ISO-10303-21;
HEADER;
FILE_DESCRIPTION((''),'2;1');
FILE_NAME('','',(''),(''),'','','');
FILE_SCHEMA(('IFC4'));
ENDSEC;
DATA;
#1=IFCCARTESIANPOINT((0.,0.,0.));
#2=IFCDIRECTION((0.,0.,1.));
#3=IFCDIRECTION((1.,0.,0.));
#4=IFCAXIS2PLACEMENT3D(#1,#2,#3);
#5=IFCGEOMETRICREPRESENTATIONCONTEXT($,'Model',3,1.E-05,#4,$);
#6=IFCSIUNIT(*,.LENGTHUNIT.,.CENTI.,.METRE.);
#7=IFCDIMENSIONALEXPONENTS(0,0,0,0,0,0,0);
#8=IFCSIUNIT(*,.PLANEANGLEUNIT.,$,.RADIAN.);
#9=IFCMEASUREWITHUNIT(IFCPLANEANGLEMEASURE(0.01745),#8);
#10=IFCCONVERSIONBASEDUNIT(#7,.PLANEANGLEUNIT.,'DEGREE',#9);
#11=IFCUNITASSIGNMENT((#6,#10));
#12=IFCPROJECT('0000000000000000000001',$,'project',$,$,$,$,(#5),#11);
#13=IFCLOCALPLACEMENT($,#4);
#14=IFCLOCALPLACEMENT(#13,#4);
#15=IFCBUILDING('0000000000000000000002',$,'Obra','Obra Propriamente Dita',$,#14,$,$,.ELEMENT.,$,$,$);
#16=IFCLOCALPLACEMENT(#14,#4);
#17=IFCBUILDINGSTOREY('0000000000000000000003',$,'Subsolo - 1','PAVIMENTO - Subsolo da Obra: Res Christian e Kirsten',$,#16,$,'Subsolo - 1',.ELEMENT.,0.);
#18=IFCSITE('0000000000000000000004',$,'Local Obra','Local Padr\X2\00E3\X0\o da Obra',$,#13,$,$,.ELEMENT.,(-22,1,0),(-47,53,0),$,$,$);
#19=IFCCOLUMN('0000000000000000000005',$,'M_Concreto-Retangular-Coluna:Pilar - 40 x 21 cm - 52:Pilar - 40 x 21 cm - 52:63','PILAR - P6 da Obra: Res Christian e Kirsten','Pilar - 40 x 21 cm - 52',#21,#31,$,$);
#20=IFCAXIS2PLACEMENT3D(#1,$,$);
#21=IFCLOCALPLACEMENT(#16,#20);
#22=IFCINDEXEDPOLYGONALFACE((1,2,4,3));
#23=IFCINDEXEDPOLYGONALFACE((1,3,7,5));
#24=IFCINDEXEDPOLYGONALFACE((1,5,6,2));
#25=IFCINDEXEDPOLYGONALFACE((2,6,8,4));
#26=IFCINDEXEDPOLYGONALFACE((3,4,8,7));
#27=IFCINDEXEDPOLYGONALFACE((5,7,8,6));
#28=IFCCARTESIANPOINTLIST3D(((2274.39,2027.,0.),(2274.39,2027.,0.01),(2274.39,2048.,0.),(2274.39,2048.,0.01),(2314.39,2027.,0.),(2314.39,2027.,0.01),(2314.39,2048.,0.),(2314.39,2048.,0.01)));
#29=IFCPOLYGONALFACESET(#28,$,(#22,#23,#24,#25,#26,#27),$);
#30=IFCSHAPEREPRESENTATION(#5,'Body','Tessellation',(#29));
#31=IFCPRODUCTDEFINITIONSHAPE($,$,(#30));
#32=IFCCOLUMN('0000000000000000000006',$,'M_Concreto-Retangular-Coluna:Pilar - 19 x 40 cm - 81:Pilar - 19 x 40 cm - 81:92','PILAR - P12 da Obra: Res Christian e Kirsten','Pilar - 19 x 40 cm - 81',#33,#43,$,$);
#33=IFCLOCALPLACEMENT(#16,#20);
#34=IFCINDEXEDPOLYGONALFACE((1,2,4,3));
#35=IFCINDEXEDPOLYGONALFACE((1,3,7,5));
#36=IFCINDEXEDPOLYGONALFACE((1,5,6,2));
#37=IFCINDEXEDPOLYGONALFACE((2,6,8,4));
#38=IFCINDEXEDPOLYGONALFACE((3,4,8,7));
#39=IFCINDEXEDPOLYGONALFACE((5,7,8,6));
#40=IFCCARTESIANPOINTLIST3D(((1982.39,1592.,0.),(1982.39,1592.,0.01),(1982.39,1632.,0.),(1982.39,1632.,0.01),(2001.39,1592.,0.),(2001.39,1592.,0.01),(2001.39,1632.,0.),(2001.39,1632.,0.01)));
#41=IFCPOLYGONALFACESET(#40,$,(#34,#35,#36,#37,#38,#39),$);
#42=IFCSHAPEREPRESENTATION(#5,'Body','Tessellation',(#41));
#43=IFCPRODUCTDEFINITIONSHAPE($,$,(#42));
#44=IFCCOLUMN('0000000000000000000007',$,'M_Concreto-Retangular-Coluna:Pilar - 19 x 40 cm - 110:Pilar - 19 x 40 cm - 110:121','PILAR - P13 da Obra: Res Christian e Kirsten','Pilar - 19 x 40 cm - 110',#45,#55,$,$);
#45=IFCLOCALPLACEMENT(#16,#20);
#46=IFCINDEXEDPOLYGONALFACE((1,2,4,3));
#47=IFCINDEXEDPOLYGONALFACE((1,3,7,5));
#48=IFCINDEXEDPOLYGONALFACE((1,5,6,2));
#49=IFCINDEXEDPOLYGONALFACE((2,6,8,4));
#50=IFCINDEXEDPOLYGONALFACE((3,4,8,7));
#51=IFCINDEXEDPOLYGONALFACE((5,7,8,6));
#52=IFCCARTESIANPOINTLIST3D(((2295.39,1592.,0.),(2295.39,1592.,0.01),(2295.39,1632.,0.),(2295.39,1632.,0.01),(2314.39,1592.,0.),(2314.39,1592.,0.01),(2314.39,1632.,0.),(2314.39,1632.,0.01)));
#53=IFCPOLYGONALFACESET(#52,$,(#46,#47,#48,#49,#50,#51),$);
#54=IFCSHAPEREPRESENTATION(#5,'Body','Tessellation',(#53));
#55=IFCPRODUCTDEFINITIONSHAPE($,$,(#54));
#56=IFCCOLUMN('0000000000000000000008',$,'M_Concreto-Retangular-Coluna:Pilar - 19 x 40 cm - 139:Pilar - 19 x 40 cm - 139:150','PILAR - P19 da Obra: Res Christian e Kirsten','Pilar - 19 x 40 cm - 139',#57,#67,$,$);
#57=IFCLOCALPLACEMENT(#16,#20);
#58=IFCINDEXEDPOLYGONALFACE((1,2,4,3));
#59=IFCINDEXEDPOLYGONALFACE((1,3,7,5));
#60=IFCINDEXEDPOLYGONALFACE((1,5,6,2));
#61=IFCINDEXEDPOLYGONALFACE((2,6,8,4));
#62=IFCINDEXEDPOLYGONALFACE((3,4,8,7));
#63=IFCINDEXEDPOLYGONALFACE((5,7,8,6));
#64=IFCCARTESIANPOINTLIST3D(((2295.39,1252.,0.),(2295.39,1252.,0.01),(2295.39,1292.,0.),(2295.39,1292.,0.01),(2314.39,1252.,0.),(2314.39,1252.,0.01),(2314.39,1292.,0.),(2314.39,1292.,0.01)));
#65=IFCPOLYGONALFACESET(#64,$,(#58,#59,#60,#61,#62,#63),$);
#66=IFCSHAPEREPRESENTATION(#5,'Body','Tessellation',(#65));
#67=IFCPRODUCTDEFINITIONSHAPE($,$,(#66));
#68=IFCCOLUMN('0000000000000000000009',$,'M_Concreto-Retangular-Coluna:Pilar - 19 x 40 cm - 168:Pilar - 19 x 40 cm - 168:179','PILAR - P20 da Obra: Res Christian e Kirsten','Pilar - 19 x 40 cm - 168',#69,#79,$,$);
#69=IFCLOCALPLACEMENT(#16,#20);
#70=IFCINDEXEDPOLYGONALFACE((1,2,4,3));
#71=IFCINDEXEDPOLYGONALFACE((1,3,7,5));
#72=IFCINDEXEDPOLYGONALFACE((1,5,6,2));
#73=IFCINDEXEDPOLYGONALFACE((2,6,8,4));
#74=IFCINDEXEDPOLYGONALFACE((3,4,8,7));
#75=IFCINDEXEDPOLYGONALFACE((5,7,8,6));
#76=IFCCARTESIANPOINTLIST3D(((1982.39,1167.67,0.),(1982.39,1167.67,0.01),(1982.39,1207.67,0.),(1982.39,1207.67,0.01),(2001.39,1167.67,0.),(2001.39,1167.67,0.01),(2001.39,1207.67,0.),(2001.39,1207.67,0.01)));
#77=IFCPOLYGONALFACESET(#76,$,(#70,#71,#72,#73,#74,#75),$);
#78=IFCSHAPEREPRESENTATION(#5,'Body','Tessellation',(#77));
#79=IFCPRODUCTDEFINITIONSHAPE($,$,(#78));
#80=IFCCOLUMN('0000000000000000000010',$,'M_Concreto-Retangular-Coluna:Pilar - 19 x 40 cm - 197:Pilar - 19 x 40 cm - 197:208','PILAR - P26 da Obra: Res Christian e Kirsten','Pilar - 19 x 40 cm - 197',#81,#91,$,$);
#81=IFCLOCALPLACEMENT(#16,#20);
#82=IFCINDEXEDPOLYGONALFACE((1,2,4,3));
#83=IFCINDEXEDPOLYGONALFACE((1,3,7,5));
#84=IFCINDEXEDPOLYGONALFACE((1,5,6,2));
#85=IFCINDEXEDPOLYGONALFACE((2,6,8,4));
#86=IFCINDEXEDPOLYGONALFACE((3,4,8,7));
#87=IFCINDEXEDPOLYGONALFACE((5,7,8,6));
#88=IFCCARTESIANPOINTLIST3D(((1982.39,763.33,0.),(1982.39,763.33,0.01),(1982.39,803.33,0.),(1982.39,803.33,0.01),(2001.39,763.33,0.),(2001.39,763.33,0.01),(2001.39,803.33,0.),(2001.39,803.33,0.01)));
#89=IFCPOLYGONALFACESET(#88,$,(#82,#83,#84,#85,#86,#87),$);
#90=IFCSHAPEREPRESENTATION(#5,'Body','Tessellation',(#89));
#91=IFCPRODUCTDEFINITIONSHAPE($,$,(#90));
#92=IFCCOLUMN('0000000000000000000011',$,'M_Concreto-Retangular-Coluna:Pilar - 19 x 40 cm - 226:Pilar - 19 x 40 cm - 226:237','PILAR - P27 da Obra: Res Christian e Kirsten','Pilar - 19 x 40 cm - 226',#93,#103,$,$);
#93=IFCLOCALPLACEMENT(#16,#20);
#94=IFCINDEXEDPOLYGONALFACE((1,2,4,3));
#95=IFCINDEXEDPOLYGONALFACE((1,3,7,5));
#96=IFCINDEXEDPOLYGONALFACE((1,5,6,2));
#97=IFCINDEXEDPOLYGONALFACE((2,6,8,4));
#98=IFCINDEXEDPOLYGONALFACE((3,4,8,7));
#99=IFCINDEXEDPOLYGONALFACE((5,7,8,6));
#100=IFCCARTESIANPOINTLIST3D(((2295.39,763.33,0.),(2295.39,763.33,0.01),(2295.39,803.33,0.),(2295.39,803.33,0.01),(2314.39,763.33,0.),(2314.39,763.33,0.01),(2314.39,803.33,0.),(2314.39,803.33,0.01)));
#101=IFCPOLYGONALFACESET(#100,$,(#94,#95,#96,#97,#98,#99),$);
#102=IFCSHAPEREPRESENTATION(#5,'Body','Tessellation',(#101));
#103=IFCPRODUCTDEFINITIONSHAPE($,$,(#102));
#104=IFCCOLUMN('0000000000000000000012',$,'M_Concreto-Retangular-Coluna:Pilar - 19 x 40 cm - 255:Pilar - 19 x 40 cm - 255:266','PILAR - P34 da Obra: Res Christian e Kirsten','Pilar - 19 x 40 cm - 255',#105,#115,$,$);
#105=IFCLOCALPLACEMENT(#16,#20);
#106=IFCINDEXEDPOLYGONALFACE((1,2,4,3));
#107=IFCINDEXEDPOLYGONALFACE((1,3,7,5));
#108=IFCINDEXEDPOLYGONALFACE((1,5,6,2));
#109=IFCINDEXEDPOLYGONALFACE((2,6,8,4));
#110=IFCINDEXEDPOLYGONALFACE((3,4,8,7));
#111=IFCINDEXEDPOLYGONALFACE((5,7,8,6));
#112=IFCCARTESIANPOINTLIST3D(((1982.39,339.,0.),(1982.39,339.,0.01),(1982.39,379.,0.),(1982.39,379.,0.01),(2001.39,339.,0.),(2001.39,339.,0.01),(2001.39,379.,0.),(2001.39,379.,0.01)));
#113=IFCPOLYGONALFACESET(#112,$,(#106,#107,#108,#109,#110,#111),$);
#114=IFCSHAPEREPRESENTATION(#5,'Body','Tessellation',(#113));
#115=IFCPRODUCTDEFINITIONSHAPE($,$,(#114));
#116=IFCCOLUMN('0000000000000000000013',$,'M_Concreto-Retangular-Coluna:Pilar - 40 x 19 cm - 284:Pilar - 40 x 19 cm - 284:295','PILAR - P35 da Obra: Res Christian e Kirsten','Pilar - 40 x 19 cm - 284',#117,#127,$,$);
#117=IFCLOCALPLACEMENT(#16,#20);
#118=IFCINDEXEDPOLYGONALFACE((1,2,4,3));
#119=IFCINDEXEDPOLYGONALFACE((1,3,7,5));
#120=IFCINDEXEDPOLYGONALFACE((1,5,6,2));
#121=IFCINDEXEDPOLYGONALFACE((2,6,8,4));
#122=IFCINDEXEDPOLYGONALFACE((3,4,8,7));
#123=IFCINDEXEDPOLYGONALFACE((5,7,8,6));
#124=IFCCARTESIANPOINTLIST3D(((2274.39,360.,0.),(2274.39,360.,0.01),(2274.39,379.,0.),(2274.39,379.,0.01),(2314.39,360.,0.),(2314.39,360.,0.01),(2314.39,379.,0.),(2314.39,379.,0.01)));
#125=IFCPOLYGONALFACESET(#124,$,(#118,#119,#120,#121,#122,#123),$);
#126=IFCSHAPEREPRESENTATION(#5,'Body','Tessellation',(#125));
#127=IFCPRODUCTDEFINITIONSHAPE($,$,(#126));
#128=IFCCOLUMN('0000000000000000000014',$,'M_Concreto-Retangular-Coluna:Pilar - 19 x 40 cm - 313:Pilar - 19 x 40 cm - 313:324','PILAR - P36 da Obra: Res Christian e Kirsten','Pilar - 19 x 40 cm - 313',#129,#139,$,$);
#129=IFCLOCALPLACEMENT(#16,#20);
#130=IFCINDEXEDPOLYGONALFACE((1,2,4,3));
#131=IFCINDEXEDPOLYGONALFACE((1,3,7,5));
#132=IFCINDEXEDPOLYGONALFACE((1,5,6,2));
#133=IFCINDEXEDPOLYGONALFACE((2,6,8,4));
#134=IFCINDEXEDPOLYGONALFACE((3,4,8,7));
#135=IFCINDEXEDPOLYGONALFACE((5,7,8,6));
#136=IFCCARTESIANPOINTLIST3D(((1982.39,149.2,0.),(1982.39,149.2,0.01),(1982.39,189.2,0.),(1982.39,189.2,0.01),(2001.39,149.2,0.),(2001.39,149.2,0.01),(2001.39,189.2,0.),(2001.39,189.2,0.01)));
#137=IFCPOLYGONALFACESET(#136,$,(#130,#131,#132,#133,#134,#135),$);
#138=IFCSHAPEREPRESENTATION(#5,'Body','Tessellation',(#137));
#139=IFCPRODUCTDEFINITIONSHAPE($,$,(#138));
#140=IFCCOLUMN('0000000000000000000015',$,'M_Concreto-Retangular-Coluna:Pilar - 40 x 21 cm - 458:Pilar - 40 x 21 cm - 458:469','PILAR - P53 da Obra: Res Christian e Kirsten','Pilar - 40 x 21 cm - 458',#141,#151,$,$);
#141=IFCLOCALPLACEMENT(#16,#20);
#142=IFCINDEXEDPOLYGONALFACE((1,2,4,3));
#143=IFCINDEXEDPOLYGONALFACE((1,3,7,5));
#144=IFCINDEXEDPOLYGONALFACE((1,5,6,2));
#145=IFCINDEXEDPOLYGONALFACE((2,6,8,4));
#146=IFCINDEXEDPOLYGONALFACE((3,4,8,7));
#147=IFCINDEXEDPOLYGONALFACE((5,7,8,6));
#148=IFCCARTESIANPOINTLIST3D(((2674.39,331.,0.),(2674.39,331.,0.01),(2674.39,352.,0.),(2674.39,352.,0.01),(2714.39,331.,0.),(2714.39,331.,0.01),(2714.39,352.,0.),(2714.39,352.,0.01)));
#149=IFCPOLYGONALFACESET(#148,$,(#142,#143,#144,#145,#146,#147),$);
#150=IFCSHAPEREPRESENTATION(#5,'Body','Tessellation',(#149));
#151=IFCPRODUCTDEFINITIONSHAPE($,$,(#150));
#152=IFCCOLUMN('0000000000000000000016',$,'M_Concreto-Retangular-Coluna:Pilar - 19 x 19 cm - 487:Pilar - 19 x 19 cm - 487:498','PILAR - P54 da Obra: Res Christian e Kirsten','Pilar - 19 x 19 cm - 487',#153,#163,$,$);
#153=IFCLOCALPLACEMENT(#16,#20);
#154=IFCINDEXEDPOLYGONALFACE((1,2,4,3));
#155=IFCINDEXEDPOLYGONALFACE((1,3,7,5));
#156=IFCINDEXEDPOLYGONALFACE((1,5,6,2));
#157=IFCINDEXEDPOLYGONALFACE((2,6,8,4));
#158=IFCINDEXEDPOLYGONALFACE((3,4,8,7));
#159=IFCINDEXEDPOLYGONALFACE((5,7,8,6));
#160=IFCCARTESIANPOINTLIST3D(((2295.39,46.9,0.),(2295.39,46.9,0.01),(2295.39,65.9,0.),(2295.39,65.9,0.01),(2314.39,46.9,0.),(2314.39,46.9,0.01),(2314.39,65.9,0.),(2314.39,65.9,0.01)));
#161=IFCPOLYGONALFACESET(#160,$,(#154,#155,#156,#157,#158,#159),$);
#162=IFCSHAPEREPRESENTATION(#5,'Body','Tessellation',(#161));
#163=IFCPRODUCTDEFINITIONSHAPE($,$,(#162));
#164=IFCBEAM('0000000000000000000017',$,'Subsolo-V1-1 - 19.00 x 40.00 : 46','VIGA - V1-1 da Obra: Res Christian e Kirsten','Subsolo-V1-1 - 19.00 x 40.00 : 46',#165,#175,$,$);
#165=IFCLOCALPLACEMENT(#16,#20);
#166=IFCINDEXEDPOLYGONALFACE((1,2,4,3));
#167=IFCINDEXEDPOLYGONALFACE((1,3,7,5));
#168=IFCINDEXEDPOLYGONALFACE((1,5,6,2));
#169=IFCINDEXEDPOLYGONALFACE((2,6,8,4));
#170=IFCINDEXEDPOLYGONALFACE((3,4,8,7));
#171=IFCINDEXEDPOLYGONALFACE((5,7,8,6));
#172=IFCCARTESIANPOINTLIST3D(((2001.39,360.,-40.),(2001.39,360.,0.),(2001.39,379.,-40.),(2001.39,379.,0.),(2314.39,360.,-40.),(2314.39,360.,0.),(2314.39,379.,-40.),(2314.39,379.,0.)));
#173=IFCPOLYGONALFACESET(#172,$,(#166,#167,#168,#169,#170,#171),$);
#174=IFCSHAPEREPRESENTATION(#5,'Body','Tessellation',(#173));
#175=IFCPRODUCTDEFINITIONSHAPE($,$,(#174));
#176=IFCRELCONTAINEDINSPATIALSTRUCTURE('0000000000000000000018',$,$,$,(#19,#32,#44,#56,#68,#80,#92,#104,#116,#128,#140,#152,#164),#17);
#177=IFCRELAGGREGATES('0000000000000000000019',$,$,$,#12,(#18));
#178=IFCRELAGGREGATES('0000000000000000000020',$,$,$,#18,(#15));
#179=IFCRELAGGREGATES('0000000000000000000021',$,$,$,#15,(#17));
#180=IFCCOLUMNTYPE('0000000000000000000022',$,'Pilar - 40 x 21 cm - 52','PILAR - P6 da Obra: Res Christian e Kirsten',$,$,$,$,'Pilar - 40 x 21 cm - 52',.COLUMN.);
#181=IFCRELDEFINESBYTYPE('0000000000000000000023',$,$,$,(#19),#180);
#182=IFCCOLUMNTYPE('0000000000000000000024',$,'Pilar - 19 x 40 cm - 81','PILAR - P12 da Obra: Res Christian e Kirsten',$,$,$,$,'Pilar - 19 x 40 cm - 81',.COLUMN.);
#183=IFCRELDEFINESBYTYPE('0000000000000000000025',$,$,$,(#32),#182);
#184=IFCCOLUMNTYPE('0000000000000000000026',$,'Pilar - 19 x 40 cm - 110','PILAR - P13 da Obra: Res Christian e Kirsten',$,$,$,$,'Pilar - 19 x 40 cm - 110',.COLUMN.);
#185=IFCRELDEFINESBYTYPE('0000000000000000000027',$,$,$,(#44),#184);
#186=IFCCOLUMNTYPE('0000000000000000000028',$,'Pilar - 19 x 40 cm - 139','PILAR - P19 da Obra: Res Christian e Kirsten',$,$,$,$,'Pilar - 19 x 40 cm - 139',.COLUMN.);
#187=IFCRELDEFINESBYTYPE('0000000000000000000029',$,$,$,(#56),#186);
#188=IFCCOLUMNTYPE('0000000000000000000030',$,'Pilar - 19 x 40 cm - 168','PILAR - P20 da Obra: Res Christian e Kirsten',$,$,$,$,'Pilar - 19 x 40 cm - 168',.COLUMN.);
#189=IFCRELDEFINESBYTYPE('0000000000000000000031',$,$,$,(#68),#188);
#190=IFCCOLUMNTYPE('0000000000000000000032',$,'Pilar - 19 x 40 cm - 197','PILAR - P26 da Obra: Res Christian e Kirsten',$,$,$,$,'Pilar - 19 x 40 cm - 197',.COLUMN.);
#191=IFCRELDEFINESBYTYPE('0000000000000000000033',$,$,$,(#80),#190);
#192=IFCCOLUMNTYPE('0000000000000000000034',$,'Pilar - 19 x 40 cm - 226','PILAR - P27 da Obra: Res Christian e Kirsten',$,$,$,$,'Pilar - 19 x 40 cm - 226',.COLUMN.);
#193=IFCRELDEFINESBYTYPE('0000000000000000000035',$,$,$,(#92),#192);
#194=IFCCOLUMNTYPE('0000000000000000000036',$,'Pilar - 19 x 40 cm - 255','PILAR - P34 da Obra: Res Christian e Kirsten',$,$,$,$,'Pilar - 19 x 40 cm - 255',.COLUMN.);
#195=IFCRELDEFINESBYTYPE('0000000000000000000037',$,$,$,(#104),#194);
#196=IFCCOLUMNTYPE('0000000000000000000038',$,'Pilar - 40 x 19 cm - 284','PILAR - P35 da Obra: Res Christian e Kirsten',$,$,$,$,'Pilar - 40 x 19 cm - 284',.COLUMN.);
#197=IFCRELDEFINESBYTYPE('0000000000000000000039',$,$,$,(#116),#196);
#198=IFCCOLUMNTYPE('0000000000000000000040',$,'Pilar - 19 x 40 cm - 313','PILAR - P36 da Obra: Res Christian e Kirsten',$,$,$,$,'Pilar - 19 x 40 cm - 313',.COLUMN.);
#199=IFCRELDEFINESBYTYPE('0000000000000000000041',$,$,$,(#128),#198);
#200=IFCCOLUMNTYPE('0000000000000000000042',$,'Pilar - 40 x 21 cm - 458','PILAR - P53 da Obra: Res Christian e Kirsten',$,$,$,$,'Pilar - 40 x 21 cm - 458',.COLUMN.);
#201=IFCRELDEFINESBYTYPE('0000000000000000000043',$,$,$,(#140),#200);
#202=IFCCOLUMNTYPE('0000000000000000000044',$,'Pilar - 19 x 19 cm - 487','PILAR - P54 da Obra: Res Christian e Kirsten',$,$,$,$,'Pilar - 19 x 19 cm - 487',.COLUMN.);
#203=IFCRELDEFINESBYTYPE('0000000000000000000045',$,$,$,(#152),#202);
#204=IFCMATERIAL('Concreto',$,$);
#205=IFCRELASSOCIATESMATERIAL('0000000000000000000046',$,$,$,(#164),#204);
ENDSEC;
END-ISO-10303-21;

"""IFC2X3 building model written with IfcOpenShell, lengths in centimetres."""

from ifc_helpers import new_model, entity, si_unit, converted_unit, frame, origin, origin_with_axes, origin_2d_with_axis, place, context, project, spatial, polyline, rectangle, outline, extrude, source, transform, mapped, material, type_object, type_shapes, element, save


model = new_model("IFC2X3")

# Units and contexts
model_context = context("Model", 3, precision=1e-05, world=origin_with_axes())
ifc_project = project(units=[si_unit("LENGTHUNIT", "METRE", prefix="CENTI"), converted_unit("PLANEANGLEUNIT", "DEGREE", entity("IfcPlaneAngleMeasure", 0.01745), si_unit("PLANEANGLEUNIT", "RADIAN"), dimensions=[0, 0, 0, 0, 0, 0, 0])], contexts=[model_context])

# Site, building, storey
site_placement = place(None, origin_with_axes())
site = spatial("IfcSite", under=ifc_project, at=site_placement, Name="Local Obra", Description="Local Padrão da Obra", CompositionType="ELEMENT", RefLatitude=(-22, 1, 0), RefLongitude=(-47, 53, 0))
building_placement = place(site_placement, origin_with_axes())
building = spatial("IfcBuilding", under=site, at=building_placement, Name="Obra", Description="Obra Propriamente Dita", CompositionType="ELEMENT")
storey_placement = place(building_placement, origin_with_axes())
storey = spatial("IfcBuildingStorey", under=building, at=storey_placement, Name="Subsolo - 1", Description="PAVIMENTO - Subsolo da Obra: Res Christian e Kirsten", LongName="Subsolo - 1", CompositionType="ELEMENT", Elevation=0.0)

# Columns
column_type_1 = type_object("IfcColumnType", Name="Pilar - 40 x 21 cm - 52", Description="PILAR - P6 da Obra: Res Christian e Kirsten", ElementType="Pilar - 40 x 21 cm - 52", PredefinedType="COLUMN")
shared_shape_1 = source(origin(), model_context, "Body", "SweptSolid", [
    extrude(rectangle(XDim=40.0, YDim=21.0, at=origin_2d_with_axis()), origin(), (0.0, 0.0, 1.0), 0.01),
])
type_shapes(column_type_1, [shared_shape_1])
column_1_placement = place(storey_placement, frame((2294.39, 2037.5, 0.0), z_axis=(0.0, 0.0, 1.0), x_axis=(1.0, 0.0, 0.0)))
element("IfcColumn", 1, at=column_1_placement, inside=storey, type_object=column_type_1, Name="M_Concreto-Retangular-Coluna:Pilar - 40 x 21 cm - 52:Pilar - 40 x 21 cm - 52:63", Description="PILAR - P6 da Obra: Res Christian e Kirsten", ObjectType="Pilar - 40 x 21 cm - 52", context=model_context, shape_type="MappedRepresentation", body=[
    mapped(shared_shape_1, transform((0.0, 0.0, 0.0), scale=1.0)),
])
column_type_2 = type_object("IfcColumnType", Name="Pilar - 19 x 40 cm - 81", Description="PILAR - P12 da Obra: Res Christian e Kirsten", ElementType="Pilar - 19 x 40 cm - 81", PredefinedType="COLUMN")
shared_shape_2 = source(origin(), model_context, "Body", "SweptSolid", [
    extrude(rectangle(XDim=19.0, YDim=40.0, at=origin_2d_with_axis()), origin(), (0.0, 0.0, 1.0), 0.01),
])
type_shapes(column_type_2, [shared_shape_2])
column_2_placement = place(storey_placement, frame((1991.89, 1612.0, 0.0), z_axis=(0.0, 0.0, 1.0), x_axis=(1.0, 0.0, 0.0)))
element("IfcColumn", 2, at=column_2_placement, inside=storey, type_object=column_type_2, Name="M_Concreto-Retangular-Coluna:Pilar - 19 x 40 cm - 81:Pilar - 19 x 40 cm - 81:92", Description="PILAR - P12 da Obra: Res Christian e Kirsten", ObjectType="Pilar - 19 x 40 cm - 81", context=model_context, shape_type="MappedRepresentation", body=[
    mapped(shared_shape_2, transform((0.0, 0.0, 0.0), scale=1.0)),
])
column_type_3 = type_object("IfcColumnType", Name="Pilar - 19 x 40 cm - 110", Description="PILAR - P13 da Obra: Res Christian e Kirsten", ElementType="Pilar - 19 x 40 cm - 110", PredefinedType="COLUMN")
shared_shape_3 = source(origin(), model_context, "Body", "SweptSolid", [
    extrude(rectangle(XDim=19.0, YDim=40.0, at=origin_2d_with_axis()), origin(), (0.0, 0.0, 1.0), 0.01),
])
type_shapes(column_type_3, [shared_shape_3])
column_3_placement = place(storey_placement, frame((2304.89, 1612.0, 0.0), z_axis=(0.0, 0.0, 1.0), x_axis=(1.0, 0.0, 0.0)))
element("IfcColumn", 3, at=column_3_placement, inside=storey, type_object=column_type_3, Name="M_Concreto-Retangular-Coluna:Pilar - 19 x 40 cm - 110:Pilar - 19 x 40 cm - 110:121", Description="PILAR - P13 da Obra: Res Christian e Kirsten", ObjectType="Pilar - 19 x 40 cm - 110", context=model_context, shape_type="MappedRepresentation", body=[
    mapped(shared_shape_3, transform((0.0, 0.0, 0.0), scale=1.0)),
])
column_type_4 = type_object("IfcColumnType", Name="Pilar - 19 x 40 cm - 139", Description="PILAR - P19 da Obra: Res Christian e Kirsten", ElementType="Pilar - 19 x 40 cm - 139", PredefinedType="COLUMN")
shared_shape_4 = source(origin(), model_context, "Body", "SweptSolid", [
    extrude(rectangle(XDim=19.0, YDim=40.0, at=origin_2d_with_axis()), origin(), (0.0, 0.0, 1.0), 0.01),
])
type_shapes(column_type_4, [shared_shape_4])
column_4_placement = place(storey_placement, frame((2304.89, 1272.0, 0.0), z_axis=(0.0, 0.0, 1.0), x_axis=(1.0, 0.0, 0.0)))
element("IfcColumn", 4, at=column_4_placement, inside=storey, type_object=column_type_4, Name="M_Concreto-Retangular-Coluna:Pilar - 19 x 40 cm - 139:Pilar - 19 x 40 cm - 139:150", Description="PILAR - P19 da Obra: Res Christian e Kirsten", ObjectType="Pilar - 19 x 40 cm - 139", context=model_context, shape_type="MappedRepresentation", body=[
    mapped(shared_shape_4, transform((0.0, 0.0, 0.0), scale=1.0)),
])
column_type_5 = type_object("IfcColumnType", Name="Pilar - 19 x 40 cm - 168", Description="PILAR - P20 da Obra: Res Christian e Kirsten", ElementType="Pilar - 19 x 40 cm - 168", PredefinedType="COLUMN")
shared_shape_5 = source(origin(), model_context, "Body", "SweptSolid", [
    extrude(rectangle(XDim=19.0, YDim=40.0, at=origin_2d_with_axis()), origin(), (0.0, 0.0, 1.0), 0.01),
])
type_shapes(column_type_5, [shared_shape_5])
column_5_placement = place(storey_placement, frame((1991.89, 1187.67, 0.0), z_axis=(0.0, 0.0, 1.0), x_axis=(1.0, 0.0, 0.0)))
element("IfcColumn", 5, at=column_5_placement, inside=storey, type_object=column_type_5, Name="M_Concreto-Retangular-Coluna:Pilar - 19 x 40 cm - 168:Pilar - 19 x 40 cm - 168:179", Description="PILAR - P20 da Obra: Res Christian e Kirsten", ObjectType="Pilar - 19 x 40 cm - 168", context=model_context, shape_type="MappedRepresentation", body=[
    mapped(shared_shape_5, transform((0.0, 0.0, 0.0), scale=1.0)),
])
column_type_6 = type_object("IfcColumnType", Name="Pilar - 19 x 40 cm - 197", Description="PILAR - P26 da Obra: Res Christian e Kirsten", ElementType="Pilar - 19 x 40 cm - 197", PredefinedType="COLUMN")
shared_shape_6 = source(origin(), model_context, "Body", "SweptSolid", [
    extrude(rectangle(XDim=19.0, YDim=40.0, at=origin_2d_with_axis()), origin(), (0.0, 0.0, 1.0), 0.01),
])
type_shapes(column_type_6, [shared_shape_6])
column_6_placement = place(storey_placement, frame((1991.89, 783.33, 0.0), z_axis=(0.0, 0.0, 1.0), x_axis=(1.0, 0.0, 0.0)))
element("IfcColumn", 6, at=column_6_placement, inside=storey, type_object=column_type_6, Name="M_Concreto-Retangular-Coluna:Pilar - 19 x 40 cm - 197:Pilar - 19 x 40 cm - 197:208", Description="PILAR - P26 da Obra: Res Christian e Kirsten", ObjectType="Pilar - 19 x 40 cm - 197", context=model_context, shape_type="MappedRepresentation", body=[
    mapped(shared_shape_6, transform((0.0, 0.0, 0.0), scale=1.0)),
])
column_type_7 = type_object("IfcColumnType", Name="Pilar - 19 x 40 cm - 226", Description="PILAR - P27 da Obra: Res Christian e Kirsten", ElementType="Pilar - 19 x 40 cm - 226", PredefinedType="COLUMN")
shared_shape_7 = source(origin(), model_context, "Body", "SweptSolid", [
    extrude(rectangle(XDim=19.0, YDim=40.0, at=origin_2d_with_axis()), origin(), (0.0, 0.0, 1.0), 0.01),
])
type_shapes(column_type_7, [shared_shape_7])
column_7_placement = place(storey_placement, frame((2304.89, 783.33, 0.0), z_axis=(0.0, 0.0, 1.0), x_axis=(1.0, 0.0, 0.0)))
element("IfcColumn", 7, at=column_7_placement, inside=storey, type_object=column_type_7, Name="M_Concreto-Retangular-Coluna:Pilar - 19 x 40 cm - 226:Pilar - 19 x 40 cm - 226:237", Description="PILAR - P27 da Obra: Res Christian e Kirsten", ObjectType="Pilar - 19 x 40 cm - 226", context=model_context, shape_type="MappedRepresentation", body=[
    mapped(shared_shape_7, transform((0.0, 0.0, 0.0), scale=1.0)),
])
column_type_8 = type_object("IfcColumnType", Name="Pilar - 19 x 40 cm - 255", Description="PILAR - P34 da Obra: Res Christian e Kirsten", ElementType="Pilar - 19 x 40 cm - 255", PredefinedType="COLUMN")
shared_shape_8 = source(origin(), model_context, "Body", "SweptSolid", [
    extrude(rectangle(XDim=19.0, YDim=40.0, at=origin_2d_with_axis()), origin(), (0.0, 0.0, 1.0), 0.01),
])
type_shapes(column_type_8, [shared_shape_8])
column_8_placement = place(storey_placement, frame((1991.89, 359.0, 0.0), z_axis=(0.0, 0.0, 1.0), x_axis=(1.0, 0.0, 0.0)))
element("IfcColumn", 8, at=column_8_placement, inside=storey, type_object=column_type_8, Name="M_Concreto-Retangular-Coluna:Pilar - 19 x 40 cm - 255:Pilar - 19 x 40 cm - 255:266", Description="PILAR - P34 da Obra: Res Christian e Kirsten", ObjectType="Pilar - 19 x 40 cm - 255", context=model_context, shape_type="MappedRepresentation", body=[
    mapped(shared_shape_8, transform((0.0, 0.0, 0.0), scale=1.0)),
])
column_type_9 = type_object("IfcColumnType", Name="Pilar - 40 x 19 cm - 284", Description="PILAR - P35 da Obra: Res Christian e Kirsten", ElementType="Pilar - 40 x 19 cm - 284", PredefinedType="COLUMN")
shared_shape_9 = source(origin(), model_context, "Body", "SweptSolid", [
    extrude(rectangle(XDim=40.0, YDim=19.0, at=origin_2d_with_axis()), origin(), (0.0, 0.0, 1.0), 0.01),
])
type_shapes(column_type_9, [shared_shape_9])
column_9_placement = place(storey_placement, frame((2294.39, 369.5, 0.0), z_axis=(0.0, 0.0, 1.0), x_axis=(1.0, 0.0, 0.0)))
element("IfcColumn", 9, at=column_9_placement, inside=storey, type_object=column_type_9, Name="M_Concreto-Retangular-Coluna:Pilar - 40 x 19 cm - 284:Pilar - 40 x 19 cm - 284:295", Description="PILAR - P35 da Obra: Res Christian e Kirsten", ObjectType="Pilar - 40 x 19 cm - 284", context=model_context, shape_type="MappedRepresentation", body=[
    mapped(shared_shape_9, transform((0.0, 0.0, 0.0), scale=1.0)),
])
column_type_10 = type_object("IfcColumnType", Name="Pilar - 19 x 40 cm - 313", Description="PILAR - P36 da Obra: Res Christian e Kirsten", ElementType="Pilar - 19 x 40 cm - 313", PredefinedType="COLUMN")
shared_shape_10 = source(origin(), model_context, "Body", "SweptSolid", [
    extrude(rectangle(XDim=19.0, YDim=40.0, at=origin_2d_with_axis()), origin(), (0.0, 0.0, 1.0), 0.01),
])
type_shapes(column_type_10, [shared_shape_10])
column_10_placement = place(storey_placement, frame((1991.89, 169.2, 0.0), z_axis=(0.0, 0.0, 1.0), x_axis=(1.0, 0.0, 0.0)))
element("IfcColumn", 10, at=column_10_placement, inside=storey, type_object=column_type_10, Name="M_Concreto-Retangular-Coluna:Pilar - 19 x 40 cm - 313:Pilar - 19 x 40 cm - 313:324", Description="PILAR - P36 da Obra: Res Christian e Kirsten", ObjectType="Pilar - 19 x 40 cm - 313", context=model_context, shape_type="MappedRepresentation", body=[
    mapped(shared_shape_10, transform((0.0, 0.0, 0.0), scale=1.0)),
])
column_type_11 = type_object("IfcColumnType", Name="Pilar - 40 x 21 cm - 458", Description="PILAR - P53 da Obra: Res Christian e Kirsten", ElementType="Pilar - 40 x 21 cm - 458", PredefinedType="COLUMN")
shared_shape_11 = source(origin(), model_context, "Body", "SweptSolid", [
    extrude(rectangle(XDim=40.0, YDim=21.0, at=origin_2d_with_axis()), origin(), (0.0, 0.0, 1.0), 0.01),
])
type_shapes(column_type_11, [shared_shape_11])
column_11_placement = place(storey_placement, frame((2694.39, 341.5, 0.0), z_axis=(0.0, 0.0, 1.0), x_axis=(1.0, 0.0, 0.0)))
element("IfcColumn", 11, at=column_11_placement, inside=storey, type_object=column_type_11, Name="M_Concreto-Retangular-Coluna:Pilar - 40 x 21 cm - 458:Pilar - 40 x 21 cm - 458:469", Description="PILAR - P53 da Obra: Res Christian e Kirsten", ObjectType="Pilar - 40 x 21 cm - 458", context=model_context, shape_type="MappedRepresentation", body=[
    mapped(shared_shape_11, transform((0.0, 0.0, 0.0), scale=1.0)),
])
column_type_12 = type_object("IfcColumnType", Name="Pilar - 19 x 19 cm - 487", Description="PILAR - P54 da Obra: Res Christian e Kirsten", ElementType="Pilar - 19 x 19 cm - 487", PredefinedType="COLUMN")
shared_shape_12 = source(origin(), model_context, "Body", "SweptSolid", [
    extrude(rectangle(XDim=19.0, YDim=19.0, at=origin_2d_with_axis()), origin(), (0.0, 0.0, 1.0), 0.01),
])
type_shapes(column_type_12, [shared_shape_12])
column_12_placement = place(storey_placement, frame((2304.89, 56.4, 0.0), z_axis=(0.0, 0.0, 1.0), x_axis=(1.0, 0.0, 0.0)))
element("IfcColumn", 12, at=column_12_placement, inside=storey, type_object=column_type_12, Name="M_Concreto-Retangular-Coluna:Pilar - 19 x 19 cm - 487:Pilar - 19 x 19 cm - 487:498", Description="PILAR - P54 da Obra: Res Christian e Kirsten", ObjectType="Pilar - 19 x 19 cm - 487", context=model_context, shape_type="MappedRepresentation", body=[
    mapped(shared_shape_12, transform((0.0, 0.0, 0.0), scale=1.0)),
])

# Beam
ifc_material_1 = material(Name="Concreto")
beam_1_placement = place(storey_placement, frame((2001.39, 379.0, 0.0), z_axis=(1.0, 0.0, 0.0), x_axis=(0.0, -1.0, 0.0)))
element("IfcBeam", 13, at=beam_1_placement, inside=storey, material=ifc_material_1, Name="Subsolo-V1-1 - 19.00 x 40.00 : 46", Description="VIGA - V1-1 da Obra: Res Christian e Kirsten", ObjectType="Subsolo-V1-1 - 19.00 x 40.00 : 46", context=model_context, shape_type="SweptSolid", body=[
    extrude(outline(polyline([(0.0, 0.0), (19.0, 0.0), (19.0, 40.0), (0.0, 40.0), (0.0, 0.0)])), origin_with_axes(), (0.0, 0.0, 1.0), 313.0),
])

save(model, "model.ifc")
